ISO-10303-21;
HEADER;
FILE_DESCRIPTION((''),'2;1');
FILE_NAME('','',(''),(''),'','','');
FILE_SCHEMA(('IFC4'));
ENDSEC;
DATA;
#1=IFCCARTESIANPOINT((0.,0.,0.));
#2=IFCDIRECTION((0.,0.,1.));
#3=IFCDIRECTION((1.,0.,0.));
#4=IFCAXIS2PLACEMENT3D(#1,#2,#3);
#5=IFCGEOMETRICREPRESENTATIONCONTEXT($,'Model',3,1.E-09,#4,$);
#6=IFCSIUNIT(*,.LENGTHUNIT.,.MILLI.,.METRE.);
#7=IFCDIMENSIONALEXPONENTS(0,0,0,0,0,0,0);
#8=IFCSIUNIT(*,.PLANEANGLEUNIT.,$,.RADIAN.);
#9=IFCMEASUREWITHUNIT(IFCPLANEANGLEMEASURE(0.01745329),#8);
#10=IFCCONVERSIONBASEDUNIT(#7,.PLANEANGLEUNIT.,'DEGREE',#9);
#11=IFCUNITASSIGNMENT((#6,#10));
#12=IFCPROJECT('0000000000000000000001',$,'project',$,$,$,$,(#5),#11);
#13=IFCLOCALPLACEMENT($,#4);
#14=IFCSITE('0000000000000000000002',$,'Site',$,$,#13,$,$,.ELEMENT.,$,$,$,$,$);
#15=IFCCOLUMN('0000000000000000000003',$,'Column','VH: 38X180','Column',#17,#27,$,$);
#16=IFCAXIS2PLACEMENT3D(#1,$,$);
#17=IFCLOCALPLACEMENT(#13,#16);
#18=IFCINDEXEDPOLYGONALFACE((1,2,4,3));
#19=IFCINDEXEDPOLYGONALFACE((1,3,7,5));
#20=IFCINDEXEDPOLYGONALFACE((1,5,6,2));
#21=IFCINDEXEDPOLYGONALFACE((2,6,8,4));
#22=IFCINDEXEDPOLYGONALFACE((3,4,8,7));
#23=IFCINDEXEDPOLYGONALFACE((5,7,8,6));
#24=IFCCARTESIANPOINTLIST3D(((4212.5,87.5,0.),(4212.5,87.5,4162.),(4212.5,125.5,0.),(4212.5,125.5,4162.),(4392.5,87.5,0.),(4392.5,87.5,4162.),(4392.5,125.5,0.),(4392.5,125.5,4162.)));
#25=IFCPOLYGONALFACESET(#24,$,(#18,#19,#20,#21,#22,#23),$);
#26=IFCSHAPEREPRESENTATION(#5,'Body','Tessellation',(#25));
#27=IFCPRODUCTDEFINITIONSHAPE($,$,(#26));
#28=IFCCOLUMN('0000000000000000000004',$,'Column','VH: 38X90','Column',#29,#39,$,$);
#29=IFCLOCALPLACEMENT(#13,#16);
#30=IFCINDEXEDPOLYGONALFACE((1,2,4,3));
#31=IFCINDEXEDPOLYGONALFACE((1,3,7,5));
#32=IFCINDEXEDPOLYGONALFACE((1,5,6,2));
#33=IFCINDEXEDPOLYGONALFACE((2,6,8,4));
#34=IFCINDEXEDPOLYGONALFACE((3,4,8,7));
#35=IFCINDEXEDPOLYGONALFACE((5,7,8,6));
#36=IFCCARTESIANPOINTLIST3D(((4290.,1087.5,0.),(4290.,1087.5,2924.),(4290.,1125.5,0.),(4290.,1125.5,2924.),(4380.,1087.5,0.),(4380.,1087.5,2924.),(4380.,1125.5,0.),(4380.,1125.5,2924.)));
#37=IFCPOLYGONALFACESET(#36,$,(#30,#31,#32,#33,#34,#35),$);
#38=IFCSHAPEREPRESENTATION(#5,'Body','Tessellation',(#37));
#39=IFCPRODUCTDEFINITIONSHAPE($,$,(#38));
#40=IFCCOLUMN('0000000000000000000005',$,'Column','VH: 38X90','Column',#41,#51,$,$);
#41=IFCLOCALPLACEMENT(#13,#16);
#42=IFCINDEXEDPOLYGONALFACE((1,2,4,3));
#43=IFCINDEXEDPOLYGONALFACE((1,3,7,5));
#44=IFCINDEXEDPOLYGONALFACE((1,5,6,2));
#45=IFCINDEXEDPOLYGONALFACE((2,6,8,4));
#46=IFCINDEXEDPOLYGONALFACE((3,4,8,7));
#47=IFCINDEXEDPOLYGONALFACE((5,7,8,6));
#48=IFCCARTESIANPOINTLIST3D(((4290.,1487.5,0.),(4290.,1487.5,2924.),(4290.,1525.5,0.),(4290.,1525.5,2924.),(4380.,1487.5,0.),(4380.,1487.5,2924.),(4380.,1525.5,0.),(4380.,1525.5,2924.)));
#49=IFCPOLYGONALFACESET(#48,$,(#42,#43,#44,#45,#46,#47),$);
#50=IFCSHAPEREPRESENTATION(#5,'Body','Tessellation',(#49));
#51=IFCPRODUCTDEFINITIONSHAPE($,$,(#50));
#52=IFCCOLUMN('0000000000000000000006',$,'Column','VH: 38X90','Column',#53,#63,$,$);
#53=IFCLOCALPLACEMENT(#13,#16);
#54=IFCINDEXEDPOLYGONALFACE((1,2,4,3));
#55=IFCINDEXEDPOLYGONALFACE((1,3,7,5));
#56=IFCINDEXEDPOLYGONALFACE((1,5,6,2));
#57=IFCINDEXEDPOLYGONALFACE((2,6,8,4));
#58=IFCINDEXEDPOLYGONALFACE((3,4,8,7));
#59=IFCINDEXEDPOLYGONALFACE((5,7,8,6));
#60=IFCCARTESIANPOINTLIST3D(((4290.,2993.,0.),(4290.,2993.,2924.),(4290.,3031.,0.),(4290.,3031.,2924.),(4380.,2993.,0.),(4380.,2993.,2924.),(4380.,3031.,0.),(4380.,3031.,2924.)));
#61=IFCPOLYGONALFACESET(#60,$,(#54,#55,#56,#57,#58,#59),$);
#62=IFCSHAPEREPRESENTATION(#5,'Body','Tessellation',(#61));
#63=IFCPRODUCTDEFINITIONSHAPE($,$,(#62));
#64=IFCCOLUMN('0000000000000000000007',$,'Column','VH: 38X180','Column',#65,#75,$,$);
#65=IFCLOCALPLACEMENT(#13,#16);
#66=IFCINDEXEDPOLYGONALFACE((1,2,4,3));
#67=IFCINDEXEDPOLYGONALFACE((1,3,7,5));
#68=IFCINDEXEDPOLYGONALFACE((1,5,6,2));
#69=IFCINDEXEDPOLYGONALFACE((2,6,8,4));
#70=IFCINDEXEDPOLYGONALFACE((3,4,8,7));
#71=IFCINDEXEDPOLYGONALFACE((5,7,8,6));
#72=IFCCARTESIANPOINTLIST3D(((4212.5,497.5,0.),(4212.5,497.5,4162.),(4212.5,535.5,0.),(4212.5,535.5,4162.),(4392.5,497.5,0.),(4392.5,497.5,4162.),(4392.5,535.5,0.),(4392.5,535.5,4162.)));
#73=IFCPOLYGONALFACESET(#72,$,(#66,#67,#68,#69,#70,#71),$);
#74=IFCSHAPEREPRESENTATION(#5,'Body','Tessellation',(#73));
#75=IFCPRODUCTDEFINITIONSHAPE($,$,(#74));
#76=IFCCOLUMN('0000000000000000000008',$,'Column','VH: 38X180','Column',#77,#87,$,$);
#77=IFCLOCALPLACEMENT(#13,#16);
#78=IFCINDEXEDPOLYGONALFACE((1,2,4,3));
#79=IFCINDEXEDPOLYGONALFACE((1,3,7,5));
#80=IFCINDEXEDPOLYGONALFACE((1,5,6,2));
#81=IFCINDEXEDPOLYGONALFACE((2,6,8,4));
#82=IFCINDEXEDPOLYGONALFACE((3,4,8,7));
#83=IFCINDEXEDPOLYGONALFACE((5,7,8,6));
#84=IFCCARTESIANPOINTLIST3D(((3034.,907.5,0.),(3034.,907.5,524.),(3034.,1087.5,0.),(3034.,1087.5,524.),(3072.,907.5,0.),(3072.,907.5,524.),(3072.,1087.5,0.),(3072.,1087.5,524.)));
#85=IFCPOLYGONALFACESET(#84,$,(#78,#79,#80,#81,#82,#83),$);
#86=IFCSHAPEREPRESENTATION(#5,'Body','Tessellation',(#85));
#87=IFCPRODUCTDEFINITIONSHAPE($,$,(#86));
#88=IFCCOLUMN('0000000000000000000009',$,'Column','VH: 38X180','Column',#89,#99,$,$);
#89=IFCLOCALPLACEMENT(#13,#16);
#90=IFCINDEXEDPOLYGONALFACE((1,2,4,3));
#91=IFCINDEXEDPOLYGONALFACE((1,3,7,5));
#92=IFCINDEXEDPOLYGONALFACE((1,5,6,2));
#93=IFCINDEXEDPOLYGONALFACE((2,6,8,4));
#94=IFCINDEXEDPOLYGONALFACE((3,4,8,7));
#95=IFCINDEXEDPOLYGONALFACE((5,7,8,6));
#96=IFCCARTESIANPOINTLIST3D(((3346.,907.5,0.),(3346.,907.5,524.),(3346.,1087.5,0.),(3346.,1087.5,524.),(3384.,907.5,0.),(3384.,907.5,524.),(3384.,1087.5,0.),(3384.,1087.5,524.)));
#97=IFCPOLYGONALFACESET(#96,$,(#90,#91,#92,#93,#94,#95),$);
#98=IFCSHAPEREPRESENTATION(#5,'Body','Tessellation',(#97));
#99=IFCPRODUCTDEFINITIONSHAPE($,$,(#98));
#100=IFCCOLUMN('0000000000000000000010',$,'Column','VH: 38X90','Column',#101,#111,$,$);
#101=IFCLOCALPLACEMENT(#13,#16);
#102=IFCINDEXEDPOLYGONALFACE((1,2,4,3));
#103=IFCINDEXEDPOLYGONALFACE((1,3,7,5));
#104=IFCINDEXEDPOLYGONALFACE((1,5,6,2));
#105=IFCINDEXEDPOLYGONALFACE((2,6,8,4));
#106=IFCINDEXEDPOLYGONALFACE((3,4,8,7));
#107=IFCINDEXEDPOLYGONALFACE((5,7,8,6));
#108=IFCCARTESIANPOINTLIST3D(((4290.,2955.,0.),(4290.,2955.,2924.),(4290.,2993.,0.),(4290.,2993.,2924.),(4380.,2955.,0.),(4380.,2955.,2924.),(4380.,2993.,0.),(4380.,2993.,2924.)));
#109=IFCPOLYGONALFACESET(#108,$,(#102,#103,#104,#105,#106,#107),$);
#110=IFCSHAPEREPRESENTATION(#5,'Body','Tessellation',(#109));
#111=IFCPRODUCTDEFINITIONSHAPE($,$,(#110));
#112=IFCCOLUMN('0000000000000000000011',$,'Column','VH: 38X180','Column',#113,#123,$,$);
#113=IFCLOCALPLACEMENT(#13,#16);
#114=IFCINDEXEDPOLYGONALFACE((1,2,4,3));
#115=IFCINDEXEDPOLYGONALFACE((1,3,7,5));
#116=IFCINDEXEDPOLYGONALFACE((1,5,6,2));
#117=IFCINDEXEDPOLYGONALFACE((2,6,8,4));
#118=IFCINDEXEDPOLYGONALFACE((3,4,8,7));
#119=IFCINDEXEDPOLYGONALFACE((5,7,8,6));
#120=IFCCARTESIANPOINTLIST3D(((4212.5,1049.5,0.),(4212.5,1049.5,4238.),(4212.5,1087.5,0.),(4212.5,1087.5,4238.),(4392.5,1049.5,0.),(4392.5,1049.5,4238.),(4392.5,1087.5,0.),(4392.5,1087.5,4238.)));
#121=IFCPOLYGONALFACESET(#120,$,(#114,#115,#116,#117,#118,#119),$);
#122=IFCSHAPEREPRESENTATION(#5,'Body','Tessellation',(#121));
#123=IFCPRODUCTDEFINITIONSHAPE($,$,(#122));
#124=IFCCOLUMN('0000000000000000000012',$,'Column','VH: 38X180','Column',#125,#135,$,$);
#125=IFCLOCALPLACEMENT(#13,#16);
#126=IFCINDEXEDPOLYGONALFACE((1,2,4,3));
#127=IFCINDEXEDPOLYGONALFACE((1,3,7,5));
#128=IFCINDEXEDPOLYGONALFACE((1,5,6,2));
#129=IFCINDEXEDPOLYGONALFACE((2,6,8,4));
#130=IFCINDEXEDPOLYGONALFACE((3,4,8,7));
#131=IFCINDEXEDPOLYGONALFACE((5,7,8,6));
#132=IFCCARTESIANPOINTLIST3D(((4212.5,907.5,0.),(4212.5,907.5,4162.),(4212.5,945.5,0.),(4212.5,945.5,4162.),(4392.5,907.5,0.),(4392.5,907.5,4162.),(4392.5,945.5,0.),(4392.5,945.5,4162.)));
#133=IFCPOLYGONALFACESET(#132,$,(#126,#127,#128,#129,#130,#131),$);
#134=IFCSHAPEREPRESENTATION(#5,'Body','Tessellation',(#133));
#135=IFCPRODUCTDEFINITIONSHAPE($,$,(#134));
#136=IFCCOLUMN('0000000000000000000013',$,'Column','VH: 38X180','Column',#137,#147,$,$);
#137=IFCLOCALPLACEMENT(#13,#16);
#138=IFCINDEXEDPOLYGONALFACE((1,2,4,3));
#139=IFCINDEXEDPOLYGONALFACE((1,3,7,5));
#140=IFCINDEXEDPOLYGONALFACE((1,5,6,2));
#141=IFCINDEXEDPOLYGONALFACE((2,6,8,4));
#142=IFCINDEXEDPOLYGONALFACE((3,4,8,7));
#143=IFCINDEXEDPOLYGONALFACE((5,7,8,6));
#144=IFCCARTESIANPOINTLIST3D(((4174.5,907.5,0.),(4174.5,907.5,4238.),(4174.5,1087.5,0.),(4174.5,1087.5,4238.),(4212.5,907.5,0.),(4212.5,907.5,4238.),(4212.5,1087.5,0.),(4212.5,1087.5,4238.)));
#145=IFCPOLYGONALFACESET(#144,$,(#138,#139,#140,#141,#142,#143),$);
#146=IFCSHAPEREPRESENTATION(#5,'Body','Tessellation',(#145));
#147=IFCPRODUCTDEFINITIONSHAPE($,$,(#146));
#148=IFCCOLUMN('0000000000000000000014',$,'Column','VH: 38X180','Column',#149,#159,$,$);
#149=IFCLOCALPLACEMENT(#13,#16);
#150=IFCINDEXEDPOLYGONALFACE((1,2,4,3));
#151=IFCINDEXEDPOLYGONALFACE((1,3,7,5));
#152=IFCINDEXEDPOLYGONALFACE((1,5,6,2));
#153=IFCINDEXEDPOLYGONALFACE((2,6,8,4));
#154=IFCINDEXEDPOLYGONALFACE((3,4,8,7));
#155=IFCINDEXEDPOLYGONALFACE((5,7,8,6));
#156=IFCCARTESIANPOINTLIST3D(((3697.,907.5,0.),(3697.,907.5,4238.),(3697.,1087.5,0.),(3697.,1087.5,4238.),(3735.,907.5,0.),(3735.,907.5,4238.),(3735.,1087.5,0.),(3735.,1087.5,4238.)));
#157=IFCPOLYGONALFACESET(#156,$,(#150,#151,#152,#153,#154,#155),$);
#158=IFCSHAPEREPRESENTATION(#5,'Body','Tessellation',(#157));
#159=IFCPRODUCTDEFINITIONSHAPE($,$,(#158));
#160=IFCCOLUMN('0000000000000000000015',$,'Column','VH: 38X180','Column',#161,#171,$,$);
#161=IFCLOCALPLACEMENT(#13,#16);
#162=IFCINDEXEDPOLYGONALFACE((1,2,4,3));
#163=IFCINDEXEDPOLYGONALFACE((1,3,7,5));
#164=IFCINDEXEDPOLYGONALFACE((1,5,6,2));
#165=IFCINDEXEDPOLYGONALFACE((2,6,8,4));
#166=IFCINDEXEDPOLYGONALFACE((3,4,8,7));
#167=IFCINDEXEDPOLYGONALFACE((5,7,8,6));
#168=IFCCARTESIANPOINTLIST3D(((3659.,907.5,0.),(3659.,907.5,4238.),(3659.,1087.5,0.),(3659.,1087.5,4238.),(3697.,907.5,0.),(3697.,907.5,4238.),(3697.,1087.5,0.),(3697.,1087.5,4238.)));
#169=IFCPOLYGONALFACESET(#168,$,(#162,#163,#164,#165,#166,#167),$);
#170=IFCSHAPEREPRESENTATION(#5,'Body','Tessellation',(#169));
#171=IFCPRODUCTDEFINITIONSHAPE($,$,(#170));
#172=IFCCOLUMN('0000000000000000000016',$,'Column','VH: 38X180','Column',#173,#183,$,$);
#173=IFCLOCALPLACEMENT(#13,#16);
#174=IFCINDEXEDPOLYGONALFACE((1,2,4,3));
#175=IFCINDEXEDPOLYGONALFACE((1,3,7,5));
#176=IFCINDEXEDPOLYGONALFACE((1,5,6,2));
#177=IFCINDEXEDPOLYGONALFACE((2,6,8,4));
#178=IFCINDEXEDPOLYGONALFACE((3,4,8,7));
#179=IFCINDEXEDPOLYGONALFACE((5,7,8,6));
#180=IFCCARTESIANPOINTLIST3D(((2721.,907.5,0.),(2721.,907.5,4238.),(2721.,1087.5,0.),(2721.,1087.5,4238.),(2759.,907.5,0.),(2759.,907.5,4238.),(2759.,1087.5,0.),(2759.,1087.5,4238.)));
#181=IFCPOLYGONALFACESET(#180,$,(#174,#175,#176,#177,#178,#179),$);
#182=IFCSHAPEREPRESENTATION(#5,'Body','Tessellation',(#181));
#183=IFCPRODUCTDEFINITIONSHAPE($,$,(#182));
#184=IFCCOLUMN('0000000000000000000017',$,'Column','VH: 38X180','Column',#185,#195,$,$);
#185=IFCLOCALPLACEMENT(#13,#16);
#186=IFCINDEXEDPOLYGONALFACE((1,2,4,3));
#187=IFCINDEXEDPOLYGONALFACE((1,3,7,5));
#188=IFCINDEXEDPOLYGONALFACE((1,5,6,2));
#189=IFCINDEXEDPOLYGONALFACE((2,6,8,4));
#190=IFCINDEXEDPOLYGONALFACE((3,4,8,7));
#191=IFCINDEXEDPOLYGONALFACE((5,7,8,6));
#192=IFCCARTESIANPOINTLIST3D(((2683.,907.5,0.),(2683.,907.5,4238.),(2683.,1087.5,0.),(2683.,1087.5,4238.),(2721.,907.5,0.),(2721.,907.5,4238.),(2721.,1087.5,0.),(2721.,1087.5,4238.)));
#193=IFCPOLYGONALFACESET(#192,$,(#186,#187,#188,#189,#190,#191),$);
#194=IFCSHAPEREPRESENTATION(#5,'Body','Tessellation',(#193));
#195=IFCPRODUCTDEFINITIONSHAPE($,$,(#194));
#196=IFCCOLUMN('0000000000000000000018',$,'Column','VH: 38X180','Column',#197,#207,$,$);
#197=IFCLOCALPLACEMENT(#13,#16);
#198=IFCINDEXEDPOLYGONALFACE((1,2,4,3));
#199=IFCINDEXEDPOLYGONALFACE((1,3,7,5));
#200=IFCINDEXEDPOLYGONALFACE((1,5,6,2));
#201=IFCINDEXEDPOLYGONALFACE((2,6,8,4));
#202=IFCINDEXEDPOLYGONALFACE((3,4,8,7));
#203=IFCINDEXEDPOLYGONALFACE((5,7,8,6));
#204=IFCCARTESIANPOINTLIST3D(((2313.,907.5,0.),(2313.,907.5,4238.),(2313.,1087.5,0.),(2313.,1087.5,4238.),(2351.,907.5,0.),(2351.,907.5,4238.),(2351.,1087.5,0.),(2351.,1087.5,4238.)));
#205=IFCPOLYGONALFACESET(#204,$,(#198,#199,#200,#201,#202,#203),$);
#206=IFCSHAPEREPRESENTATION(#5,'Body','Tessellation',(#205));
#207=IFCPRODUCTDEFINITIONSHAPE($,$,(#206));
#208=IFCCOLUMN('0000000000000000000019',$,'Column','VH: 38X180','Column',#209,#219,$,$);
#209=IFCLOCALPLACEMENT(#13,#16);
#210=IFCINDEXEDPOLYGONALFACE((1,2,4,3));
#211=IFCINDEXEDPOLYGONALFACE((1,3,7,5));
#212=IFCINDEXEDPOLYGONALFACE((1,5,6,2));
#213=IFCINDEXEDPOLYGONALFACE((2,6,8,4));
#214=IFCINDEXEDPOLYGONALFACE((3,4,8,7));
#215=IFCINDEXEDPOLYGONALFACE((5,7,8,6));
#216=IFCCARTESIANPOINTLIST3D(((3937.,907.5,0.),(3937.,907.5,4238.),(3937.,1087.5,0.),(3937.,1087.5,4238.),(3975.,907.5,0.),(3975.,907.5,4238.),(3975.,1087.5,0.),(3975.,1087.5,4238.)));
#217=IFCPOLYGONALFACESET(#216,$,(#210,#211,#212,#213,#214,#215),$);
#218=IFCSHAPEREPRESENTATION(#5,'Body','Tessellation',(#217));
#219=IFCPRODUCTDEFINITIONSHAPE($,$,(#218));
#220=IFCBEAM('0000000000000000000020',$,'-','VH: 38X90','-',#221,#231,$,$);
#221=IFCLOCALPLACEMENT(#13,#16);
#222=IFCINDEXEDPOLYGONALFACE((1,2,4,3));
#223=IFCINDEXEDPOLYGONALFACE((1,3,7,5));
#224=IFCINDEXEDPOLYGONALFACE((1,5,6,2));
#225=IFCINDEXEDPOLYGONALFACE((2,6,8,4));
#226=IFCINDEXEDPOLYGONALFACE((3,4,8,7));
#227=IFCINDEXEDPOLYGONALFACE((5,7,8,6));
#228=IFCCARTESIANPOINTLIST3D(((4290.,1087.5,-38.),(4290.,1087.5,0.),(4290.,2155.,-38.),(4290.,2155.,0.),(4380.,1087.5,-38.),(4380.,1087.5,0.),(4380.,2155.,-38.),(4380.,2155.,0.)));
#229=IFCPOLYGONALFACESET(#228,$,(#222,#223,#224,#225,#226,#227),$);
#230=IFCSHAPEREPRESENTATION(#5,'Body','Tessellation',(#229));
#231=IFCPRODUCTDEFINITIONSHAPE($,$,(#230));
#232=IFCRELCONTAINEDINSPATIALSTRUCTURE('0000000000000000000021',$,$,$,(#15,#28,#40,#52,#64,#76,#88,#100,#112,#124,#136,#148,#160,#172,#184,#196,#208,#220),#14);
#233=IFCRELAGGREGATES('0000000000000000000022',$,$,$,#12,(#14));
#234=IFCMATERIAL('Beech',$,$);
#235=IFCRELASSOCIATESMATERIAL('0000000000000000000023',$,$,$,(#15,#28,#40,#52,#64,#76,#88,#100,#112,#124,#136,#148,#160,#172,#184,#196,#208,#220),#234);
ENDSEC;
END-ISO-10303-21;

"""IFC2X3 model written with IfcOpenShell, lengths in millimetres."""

from ifc_helpers import new_model, entity, si_unit, converted_unit, frame, origin, origin_with_axes, origin_2d, place, context, project, spatial, rectangle, extrude, material, element, save


model = new_model("IFC2X3")

# Units and contexts
model_context = context("Model", 3, precision=1e-09, world=origin_with_axes())
ifc_project = project(units=[si_unit("LENGTHUNIT", "METRE", prefix="MILLI"), converted_unit("PLANEANGLEUNIT", "DEGREE", entity("IfcPlaneAngleMeasure", 0.01745329), si_unit("PLANEANGLEUNIT", "RADIAN"), dimensions=[0, 0, 0, 0, 0, 0, 0])], contexts=[model_context])

# Site
site_placement = place(None, origin_with_axes())
site = spatial("IfcSite", under=ifc_project, at=site_placement, Name="Site", CompositionType="ELEMENT")

# Columns
ifc_material = material(Name="Beech")
column_1_placement = place(None, frame((4302.5, 106.5, 0.0), z_axis=(0.0, 0.0, -1.0), x_axis=(0.0, -1.0, 0.0)))
element("IfcColumn", 1, at=column_1_placement, inside=site, material=ifc_material, Name="Column", Description="VH: 38X180", ObjectType="Column", context=model_context, shape_type="SweptSolid", body=[
    extrude(rectangle(XDim=38.0, YDim=180.0, at=origin_2d()), origin(), (0.0, 0.0, -1.0), 4162.0),
])
for number, where, z_axis, x_axis, name in (
    (2, (4335.0, 1106.5, 0.0), (0.0, 0.0, -1.0), (0.0, -1.0, 0.0), "Column"),
    (3, (4335.0, 1506.5, 0.0), (0.0, 0.0, -1.0), (0.0, -1.0, 0.0), "Column"),
    (4, (4335.0, 3012.0, 0.0), (0.0, 0.0, -1.0), (0.0, -1.0, 0.0), "Column"),
):
    element("IfcColumn", number, at=place(None, frame(where, z_axis=z_axis, x_axis=x_axis)), inside=site, material=ifc_material, Name=name, Description="VH: 38X90", ObjectType="Column", context=model_context, shape_type="SweptSolid", body=[
        extrude(rectangle(XDim=38.0, YDim=90.0, at=origin_2d()), origin(), (0.0, 0.0, -1.0), 2924.0),
    ])
column_2_placement = place(None, frame((4302.5, 516.5, 0.0), z_axis=(0.0, 0.0, -1.0), x_axis=(0.0, -1.0, 0.0)))
element("IfcColumn", 5, at=column_2_placement, inside=site, material=ifc_material, Name="Column", Description="VH: 38X180", ObjectType="Column", context=model_context, shape_type="SweptSolid", body=[
    extrude(rectangle(XDim=38.0, YDim=180.0, at=origin_2d()), origin(), (0.0, 0.0, -1.0), 4162.0),
])
for number, where, z_axis, x_axis, name in (
    (6, (3053.0, 997.5, 0.0), (0.0, 0.0, -1.0), (-1.0, 0.0, 0.0), "Column"),
    (7, (3365.0, 997.5, 0.0), (0.0, 0.0, -1.0), (1.0, 0.0, 0.0), "Column"),
):
    element("IfcColumn", number, at=place(None, frame(where, z_axis=z_axis, x_axis=x_axis)), inside=site, material=ifc_material, Name=name, Description="VH: 38X180", ObjectType="Column", context=model_context, shape_type="SweptSolid", body=[
        extrude(rectangle(XDim=38.0, YDim=180.0, at=origin_2d()), origin(), (0.0, 0.0, -1.0), 524.0),
    ])
column_3_placement = place(None, frame((4335.0, 2974.0, 0.0), z_axis=(0.0, 0.0, -1.0), x_axis=(0.0, -1.0, 0.0)))
element("IfcColumn", 8, at=column_3_placement, inside=site, material=ifc_material, Name="Column", Description="VH: 38X90", ObjectType="Column", context=model_context, shape_type="SweptSolid", body=[
    extrude(rectangle(XDim=38.0, YDim=90.0, at=origin_2d()), origin(), (0.0, 0.0, -1.0), 2924.0),
])
column_4_placement = place(None, frame((4302.5, 1068.5, 0.0), z_axis=(0.0, 0.0, -1.0), x_axis=(0.0, -1.0, 0.0)))
element("IfcColumn", 9, at=column_4_placement, inside=site, material=ifc_material, Name="Column", Description="VH: 38X180", ObjectType="Column", context=model_context, shape_type="SweptSolid", body=[
    extrude(rectangle(XDim=38.0, YDim=180.0, at=origin_2d()), origin(), (0.0, 0.0, -1.0), 4238.0),
])
column_5_placement = place(None, frame((4302.5, 926.5, 0.0), z_axis=(0.0, 0.0, -1.0), x_axis=(0.0, -1.0, 0.0)))
element("IfcColumn", 10, at=column_5_placement, inside=site, material=ifc_material, Name="Column", Description="VH: 38X180", ObjectType="Column", context=model_context, shape_type="SweptSolid", body=[
    extrude(rectangle(XDim=38.0, YDim=180.0, at=origin_2d()), origin(), (0.0, 0.0, -1.0), 4162.0),
])
for number, where, z_axis, x_axis, name in (
    (11, (4193.5, 997.5, 0.0), (0.0, 0.0, -1.0), (1.0, 0.0, 0.0), "Column"),
    (12, (3716.0, 997.5, 0.0), (0.0, 0.0, -1.0), (1.0, 0.0, 0.0), "Column"),
    (13, (3678.0, 997.5, 0.0), (0.0, 0.0, -1.0), (1.0, 0.0, 0.0), "Column"),
    (14, (2740.0, 997.5, 0.0), (0.0, 0.0, -1.0), (-1.0, 0.0, 0.0), "Column"),
    (15, (2702.0, 997.5, 0.0), (0.0, 0.0, -1.0), (-1.0, 0.0, 0.0), "Column"),
    (16, (2332.0, 997.5, 0.0), (0.0, 0.0, -1.0), (-1.0, 0.0, 0.0), "Column"),
    (17, (3956.0, 997.5, 0.0), (0.0, 0.0, -1.0), (1.0, 0.0, 0.0), "Column"),
):
    element("IfcColumn", number, at=place(None, frame(where, z_axis=z_axis, x_axis=x_axis)), inside=site, material=ifc_material, Name=name, Description="VH: 38X180", ObjectType="Column", context=model_context, shape_type="SweptSolid", body=[
        extrude(rectangle(XDim=38.0, YDim=180.0, at=origin_2d()), origin(), (0.0, 0.0, -1.0), 4238.0),
    ])

# Beam
beam_1_placement = place(None, frame((4335.0, 1087.5, -19.0), z_axis=(-0.000023, -1.0, 0.0), x_axis=(0.0, 0.0, -1.0)))
element("IfcBeam", 18, at=beam_1_placement, inside=site, material=ifc_material, Name="-", Description="VH: 38X90", ObjectType="-", context=model_context, shape_type="SweptSolid", body=[
    extrude(rectangle(XDim=38.0, YDim=90.0, at=origin_2d()), origin(), (0.0, 0.0, -1.0), 1067.5),
])

save(model, "model.ifc")
